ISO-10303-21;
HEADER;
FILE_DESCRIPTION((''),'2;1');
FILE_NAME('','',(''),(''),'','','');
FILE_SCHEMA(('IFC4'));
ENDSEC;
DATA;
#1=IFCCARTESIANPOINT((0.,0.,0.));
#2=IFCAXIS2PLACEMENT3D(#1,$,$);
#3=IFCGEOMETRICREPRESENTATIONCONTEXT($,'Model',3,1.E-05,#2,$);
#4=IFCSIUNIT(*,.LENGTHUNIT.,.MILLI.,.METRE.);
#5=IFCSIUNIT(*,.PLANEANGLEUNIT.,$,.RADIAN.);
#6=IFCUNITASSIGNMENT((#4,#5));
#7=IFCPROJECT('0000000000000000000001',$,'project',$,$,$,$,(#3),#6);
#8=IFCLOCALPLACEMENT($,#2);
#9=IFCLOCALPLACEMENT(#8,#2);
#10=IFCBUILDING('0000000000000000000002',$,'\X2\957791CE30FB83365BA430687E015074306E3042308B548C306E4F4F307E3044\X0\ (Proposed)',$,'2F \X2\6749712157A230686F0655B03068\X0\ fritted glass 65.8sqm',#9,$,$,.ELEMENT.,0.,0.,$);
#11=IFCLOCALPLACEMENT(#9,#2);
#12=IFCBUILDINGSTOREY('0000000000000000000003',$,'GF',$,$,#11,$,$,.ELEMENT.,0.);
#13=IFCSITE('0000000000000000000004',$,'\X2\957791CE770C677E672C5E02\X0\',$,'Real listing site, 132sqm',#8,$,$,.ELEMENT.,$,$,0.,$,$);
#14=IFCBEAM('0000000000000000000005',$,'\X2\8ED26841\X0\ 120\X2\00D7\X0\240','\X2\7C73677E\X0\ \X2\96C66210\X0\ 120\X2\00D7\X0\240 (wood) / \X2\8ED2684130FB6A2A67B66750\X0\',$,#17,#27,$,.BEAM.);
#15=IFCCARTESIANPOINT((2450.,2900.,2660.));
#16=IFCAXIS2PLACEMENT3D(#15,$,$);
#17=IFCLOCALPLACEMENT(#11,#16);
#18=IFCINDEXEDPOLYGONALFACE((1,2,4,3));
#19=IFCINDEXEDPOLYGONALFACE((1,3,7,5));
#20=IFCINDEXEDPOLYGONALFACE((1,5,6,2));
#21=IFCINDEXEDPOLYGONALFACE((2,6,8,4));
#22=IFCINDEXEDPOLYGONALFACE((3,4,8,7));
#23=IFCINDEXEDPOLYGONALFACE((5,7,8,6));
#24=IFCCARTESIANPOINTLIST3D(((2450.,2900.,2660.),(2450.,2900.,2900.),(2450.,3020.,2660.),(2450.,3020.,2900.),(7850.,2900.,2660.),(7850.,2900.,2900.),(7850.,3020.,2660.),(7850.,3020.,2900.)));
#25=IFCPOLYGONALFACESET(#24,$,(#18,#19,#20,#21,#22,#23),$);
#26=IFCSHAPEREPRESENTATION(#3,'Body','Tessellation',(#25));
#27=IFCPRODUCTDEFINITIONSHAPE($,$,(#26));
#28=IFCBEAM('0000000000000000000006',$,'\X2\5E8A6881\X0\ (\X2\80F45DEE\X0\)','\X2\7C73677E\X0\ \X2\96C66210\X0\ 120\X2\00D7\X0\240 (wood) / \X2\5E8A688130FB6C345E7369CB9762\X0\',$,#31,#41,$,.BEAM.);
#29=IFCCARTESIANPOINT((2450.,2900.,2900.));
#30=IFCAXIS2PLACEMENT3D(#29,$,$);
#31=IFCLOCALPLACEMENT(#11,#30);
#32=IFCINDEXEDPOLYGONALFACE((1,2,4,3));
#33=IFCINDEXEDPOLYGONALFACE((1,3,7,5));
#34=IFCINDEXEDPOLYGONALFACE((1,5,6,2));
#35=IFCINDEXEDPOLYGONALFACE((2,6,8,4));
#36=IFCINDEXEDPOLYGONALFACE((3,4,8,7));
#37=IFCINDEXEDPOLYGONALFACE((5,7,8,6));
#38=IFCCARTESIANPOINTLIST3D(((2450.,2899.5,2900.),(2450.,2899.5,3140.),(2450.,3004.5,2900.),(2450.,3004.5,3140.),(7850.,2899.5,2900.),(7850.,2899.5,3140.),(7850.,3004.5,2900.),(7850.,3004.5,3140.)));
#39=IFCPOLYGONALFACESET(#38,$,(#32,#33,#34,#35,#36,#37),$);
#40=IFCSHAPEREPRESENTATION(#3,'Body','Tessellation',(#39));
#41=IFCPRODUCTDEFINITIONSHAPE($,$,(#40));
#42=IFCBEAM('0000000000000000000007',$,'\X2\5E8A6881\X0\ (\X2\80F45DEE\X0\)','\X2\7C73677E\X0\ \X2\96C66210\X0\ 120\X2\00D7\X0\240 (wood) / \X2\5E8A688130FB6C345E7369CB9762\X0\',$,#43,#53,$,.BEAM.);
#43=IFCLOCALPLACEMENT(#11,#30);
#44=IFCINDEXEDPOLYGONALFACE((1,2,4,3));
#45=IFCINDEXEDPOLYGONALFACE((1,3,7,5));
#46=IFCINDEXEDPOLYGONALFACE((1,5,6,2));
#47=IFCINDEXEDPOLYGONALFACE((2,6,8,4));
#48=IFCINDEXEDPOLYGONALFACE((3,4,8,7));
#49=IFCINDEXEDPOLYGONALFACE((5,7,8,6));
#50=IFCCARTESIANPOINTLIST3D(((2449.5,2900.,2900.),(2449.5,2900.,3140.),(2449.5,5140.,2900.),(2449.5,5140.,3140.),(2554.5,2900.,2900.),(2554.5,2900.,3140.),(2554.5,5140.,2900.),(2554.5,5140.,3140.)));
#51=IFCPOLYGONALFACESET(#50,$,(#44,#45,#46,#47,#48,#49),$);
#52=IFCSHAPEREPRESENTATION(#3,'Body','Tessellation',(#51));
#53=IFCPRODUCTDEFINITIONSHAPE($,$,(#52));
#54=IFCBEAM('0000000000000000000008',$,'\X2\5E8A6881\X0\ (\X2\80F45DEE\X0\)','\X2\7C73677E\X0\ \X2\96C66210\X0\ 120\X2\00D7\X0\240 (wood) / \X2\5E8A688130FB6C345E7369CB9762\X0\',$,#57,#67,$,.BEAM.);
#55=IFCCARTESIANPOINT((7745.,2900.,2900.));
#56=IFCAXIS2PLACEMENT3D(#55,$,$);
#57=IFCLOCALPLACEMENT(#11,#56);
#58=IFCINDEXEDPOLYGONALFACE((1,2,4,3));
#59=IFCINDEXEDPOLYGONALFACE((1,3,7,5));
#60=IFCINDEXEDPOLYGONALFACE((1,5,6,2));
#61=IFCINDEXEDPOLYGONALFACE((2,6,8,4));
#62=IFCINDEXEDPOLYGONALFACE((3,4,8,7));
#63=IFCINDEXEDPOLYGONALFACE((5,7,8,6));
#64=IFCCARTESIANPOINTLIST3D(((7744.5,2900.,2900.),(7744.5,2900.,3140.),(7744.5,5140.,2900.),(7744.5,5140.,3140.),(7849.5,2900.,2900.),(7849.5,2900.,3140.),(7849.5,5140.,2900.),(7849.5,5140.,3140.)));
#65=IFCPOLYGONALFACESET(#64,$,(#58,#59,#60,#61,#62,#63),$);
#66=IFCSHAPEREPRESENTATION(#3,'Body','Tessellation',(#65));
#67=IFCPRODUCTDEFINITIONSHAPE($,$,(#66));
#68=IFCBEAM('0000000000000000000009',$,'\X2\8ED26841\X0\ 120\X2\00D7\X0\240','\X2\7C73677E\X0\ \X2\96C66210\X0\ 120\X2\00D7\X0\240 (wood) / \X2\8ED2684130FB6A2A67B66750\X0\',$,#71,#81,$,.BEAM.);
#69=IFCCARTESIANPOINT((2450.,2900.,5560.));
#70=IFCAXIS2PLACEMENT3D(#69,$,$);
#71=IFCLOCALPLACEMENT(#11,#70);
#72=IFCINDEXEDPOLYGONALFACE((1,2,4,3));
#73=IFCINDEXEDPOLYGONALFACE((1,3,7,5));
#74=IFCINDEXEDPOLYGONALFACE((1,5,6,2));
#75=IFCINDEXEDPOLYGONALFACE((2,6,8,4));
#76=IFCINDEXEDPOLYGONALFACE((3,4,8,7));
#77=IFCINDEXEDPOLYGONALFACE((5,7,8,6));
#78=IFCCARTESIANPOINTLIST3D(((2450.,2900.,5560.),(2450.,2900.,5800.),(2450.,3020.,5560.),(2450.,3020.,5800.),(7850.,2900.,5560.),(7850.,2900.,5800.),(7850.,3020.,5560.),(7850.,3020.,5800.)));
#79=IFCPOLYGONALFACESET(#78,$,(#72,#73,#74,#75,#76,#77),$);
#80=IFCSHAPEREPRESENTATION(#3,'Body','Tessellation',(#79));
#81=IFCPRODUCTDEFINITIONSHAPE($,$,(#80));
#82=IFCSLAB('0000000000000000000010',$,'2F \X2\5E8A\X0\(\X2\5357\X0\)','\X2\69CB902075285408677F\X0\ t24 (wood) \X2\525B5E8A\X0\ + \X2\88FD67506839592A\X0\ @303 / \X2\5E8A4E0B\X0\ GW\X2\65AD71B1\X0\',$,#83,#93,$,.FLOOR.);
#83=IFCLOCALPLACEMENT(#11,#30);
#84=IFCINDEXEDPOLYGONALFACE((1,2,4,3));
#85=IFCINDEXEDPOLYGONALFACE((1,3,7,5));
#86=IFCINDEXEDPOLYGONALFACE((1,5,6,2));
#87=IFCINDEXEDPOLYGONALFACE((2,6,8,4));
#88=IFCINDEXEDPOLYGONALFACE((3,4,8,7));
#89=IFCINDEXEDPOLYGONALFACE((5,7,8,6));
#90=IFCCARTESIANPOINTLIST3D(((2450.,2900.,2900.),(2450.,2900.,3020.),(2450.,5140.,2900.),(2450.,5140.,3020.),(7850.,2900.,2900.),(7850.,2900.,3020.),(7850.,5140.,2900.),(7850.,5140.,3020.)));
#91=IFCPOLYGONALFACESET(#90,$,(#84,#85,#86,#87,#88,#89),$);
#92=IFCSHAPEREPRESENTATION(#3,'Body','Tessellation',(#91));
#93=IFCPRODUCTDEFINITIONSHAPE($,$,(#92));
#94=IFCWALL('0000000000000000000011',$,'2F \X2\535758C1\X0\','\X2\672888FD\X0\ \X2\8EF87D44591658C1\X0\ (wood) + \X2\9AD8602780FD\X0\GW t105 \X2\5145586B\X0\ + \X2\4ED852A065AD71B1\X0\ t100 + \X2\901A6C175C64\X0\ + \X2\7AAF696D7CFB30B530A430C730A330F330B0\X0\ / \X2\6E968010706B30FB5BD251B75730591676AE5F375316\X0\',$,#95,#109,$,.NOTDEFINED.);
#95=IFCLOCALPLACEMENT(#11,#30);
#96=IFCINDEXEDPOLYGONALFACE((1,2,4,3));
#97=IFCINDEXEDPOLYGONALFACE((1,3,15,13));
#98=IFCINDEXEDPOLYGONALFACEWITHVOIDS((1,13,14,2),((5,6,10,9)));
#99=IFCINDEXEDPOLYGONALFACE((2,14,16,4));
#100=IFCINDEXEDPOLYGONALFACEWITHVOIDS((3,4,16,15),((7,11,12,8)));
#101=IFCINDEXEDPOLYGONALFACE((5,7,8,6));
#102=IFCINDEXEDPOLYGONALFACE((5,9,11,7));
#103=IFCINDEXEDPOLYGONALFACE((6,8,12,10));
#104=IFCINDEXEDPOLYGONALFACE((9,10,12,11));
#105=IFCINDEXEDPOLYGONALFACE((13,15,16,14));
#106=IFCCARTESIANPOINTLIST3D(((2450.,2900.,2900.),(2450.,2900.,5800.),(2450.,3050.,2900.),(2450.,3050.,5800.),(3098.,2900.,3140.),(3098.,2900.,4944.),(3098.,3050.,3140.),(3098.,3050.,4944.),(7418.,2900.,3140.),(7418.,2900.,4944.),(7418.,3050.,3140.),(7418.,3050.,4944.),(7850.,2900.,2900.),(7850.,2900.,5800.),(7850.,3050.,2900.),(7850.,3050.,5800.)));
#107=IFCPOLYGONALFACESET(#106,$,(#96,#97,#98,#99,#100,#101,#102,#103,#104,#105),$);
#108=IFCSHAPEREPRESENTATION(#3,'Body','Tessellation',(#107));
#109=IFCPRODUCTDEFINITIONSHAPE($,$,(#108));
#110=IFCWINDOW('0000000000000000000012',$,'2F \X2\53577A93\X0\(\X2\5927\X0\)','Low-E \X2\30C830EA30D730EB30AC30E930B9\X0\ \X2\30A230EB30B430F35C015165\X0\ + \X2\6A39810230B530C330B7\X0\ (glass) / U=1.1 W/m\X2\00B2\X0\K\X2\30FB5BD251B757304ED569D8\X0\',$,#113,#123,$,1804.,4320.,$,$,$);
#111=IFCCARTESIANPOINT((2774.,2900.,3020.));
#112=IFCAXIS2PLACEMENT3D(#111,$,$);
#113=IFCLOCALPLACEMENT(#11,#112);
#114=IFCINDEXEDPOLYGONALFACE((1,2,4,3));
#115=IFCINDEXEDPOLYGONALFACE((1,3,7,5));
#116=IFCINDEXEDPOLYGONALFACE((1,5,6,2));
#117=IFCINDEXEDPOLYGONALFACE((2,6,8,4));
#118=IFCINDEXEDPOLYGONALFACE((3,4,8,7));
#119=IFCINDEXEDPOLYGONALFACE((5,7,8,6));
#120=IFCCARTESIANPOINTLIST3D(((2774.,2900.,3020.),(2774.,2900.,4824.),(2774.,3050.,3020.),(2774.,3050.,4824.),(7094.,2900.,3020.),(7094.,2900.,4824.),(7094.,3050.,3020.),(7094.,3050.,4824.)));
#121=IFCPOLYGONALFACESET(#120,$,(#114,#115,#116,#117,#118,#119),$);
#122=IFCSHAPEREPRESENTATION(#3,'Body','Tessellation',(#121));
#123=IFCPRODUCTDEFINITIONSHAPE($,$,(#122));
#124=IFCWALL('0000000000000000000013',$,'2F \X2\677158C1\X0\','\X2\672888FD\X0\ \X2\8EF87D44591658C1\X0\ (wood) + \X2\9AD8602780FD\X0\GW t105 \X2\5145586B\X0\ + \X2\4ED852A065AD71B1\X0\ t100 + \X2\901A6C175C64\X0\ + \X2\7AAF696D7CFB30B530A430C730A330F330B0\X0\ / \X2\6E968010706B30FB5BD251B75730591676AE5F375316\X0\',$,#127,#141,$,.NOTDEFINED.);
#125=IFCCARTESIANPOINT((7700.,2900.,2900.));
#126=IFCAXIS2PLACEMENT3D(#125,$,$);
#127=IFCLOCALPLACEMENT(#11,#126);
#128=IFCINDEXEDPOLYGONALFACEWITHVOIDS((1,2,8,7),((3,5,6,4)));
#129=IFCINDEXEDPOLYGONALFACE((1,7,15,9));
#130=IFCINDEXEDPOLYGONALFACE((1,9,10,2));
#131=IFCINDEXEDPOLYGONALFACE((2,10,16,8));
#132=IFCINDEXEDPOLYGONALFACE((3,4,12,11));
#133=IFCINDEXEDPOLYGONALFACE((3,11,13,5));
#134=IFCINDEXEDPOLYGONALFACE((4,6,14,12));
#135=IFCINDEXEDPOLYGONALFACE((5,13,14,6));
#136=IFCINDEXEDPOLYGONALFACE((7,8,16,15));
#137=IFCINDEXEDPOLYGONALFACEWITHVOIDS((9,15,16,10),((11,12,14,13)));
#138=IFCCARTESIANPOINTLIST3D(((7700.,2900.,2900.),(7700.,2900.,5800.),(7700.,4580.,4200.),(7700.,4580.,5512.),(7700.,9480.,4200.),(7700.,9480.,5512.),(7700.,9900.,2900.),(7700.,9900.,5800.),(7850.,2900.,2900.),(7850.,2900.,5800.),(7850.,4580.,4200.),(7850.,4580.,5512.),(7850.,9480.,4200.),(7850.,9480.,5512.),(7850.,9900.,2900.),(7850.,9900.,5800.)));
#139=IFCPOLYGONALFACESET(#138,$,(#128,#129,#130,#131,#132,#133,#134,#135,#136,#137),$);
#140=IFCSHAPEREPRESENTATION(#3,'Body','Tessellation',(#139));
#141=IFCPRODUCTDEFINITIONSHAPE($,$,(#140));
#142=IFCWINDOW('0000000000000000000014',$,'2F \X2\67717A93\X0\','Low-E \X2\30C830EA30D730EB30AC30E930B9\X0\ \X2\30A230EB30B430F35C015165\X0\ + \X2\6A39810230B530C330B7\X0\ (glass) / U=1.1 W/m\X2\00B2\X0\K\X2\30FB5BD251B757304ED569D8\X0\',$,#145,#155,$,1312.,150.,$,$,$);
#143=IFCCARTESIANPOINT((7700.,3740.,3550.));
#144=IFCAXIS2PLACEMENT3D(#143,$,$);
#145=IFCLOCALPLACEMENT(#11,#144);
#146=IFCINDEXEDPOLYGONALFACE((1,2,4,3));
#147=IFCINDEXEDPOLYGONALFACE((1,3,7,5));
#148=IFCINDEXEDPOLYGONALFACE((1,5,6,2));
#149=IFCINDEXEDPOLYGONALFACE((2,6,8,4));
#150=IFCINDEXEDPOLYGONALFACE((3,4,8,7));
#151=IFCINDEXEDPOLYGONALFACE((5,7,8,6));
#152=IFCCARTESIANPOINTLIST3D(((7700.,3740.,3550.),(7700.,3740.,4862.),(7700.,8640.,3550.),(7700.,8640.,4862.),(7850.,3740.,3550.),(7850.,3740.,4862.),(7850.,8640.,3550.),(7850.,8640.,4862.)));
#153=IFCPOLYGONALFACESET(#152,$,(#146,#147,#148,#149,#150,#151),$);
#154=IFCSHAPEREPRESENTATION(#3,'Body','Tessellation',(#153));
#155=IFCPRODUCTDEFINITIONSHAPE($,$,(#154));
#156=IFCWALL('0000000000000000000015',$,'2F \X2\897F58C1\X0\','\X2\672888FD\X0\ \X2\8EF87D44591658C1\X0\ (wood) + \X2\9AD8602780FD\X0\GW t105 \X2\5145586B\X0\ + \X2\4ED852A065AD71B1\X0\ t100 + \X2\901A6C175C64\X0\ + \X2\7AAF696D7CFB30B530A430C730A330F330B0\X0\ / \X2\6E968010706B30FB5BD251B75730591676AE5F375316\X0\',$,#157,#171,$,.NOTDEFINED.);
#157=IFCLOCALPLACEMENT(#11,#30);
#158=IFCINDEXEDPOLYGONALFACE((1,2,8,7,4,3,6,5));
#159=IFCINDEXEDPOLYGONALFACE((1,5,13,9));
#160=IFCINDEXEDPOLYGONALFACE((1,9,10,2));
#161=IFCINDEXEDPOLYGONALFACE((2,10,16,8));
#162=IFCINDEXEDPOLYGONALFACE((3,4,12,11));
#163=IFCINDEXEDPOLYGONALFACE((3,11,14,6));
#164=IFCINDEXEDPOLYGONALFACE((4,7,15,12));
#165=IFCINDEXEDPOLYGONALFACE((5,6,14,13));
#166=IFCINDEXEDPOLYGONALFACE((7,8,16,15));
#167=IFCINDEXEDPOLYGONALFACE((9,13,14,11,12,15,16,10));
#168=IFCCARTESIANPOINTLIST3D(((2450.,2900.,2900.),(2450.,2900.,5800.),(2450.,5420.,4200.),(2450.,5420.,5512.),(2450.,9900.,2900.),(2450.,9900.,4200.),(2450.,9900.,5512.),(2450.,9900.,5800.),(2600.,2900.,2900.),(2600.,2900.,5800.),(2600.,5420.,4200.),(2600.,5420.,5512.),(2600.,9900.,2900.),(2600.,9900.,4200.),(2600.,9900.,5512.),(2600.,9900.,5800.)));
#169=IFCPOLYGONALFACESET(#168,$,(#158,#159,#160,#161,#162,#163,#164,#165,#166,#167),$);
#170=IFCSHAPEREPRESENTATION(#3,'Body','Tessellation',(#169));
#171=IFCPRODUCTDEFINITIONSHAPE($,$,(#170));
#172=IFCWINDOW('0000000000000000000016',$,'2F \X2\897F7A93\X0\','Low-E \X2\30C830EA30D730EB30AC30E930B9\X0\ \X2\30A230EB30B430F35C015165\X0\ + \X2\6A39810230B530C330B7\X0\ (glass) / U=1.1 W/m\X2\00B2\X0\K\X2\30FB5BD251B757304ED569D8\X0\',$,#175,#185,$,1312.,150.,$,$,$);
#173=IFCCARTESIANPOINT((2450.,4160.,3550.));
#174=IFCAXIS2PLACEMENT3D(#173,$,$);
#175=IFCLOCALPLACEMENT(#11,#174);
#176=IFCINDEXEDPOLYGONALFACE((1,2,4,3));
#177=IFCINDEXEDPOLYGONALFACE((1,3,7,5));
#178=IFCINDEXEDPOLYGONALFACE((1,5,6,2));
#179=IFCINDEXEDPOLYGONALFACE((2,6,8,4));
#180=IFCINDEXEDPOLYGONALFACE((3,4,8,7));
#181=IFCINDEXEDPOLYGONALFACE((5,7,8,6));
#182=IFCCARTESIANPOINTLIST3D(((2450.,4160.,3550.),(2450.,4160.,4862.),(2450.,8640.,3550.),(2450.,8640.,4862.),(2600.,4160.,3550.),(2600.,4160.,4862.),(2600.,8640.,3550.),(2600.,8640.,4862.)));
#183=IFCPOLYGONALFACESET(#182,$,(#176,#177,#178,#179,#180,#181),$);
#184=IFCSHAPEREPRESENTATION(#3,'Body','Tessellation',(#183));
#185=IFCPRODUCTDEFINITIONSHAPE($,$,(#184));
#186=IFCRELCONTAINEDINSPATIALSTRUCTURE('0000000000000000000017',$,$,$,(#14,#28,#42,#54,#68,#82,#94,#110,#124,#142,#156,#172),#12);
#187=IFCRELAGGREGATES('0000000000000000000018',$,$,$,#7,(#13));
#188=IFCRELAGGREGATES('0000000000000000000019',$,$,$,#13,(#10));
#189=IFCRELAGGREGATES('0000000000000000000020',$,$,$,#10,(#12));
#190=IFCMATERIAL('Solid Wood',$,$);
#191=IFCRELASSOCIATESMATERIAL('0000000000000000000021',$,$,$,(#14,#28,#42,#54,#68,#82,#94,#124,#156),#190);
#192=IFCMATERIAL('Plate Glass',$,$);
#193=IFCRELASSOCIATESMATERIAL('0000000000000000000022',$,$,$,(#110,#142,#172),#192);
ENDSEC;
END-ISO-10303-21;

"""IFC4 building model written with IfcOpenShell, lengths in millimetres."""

from ifc_helpers import new_model, si_unit, frame, frame_2d, origin, place, context, project, spatial, rectangle, extrude, material, element, fill, save


model = new_model("IFC4")

# Units and contexts
model_context = context("Model", 3, precision=1e-05, world=origin())
ifc_project = project(units=[si_unit("LENGTHUNIT", "METRE", prefix="MILLI"), si_unit("PLANEANGLEUNIT", "RADIAN")], contexts=[model_context])

# Site, building, storey
site_placement = place(None, origin())
site = spatial("IfcSite", under=ifc_project, at=site_placement, Name="長野県松本市", ObjectType="Real listing site, 132sqm", CompositionType="ELEMENT", RefElevation=0.0)
building_placement = place(site_placement, origin())
building = spatial("IfcBuilding", under=site, at=building_placement, Name="長野・茶室と縁側のある和の住まい (Proposed)", ObjectType="2F 杉無垢と漆喰と fritted glass 65.8sqm", CompositionType="ELEMENT", ElevationOfRefHeight=0.0, ElevationOfTerrain=0.0)
storey_placement = place(building_placement, origin())
storey = spatial("IfcBuildingStorey", under=building, at=storey_placement, Name="GF", CompositionType="ELEMENT", Elevation=0.0)

# Shared definitions
ifc_material_1 = material(Name="Solid Wood")

# Beams
beam_1_placement = place(storey_placement, frame((2450.0, 2900.0, 2660.0)))
element("IfcBeam", 1, at=beam_1_placement, inside=storey, material=ifc_material_1, Name="軒桁 120×240", Description="米松 集成 120×240 (wood) / 軒桁・横架材", PredefinedType="BEAM", context=model_context, shape_type="SweptSolid", body=[
    extrude(rectangle(XDim=5400.0, YDim=120.0, at=frame_2d((2700.0, 60.0))), frame((2450.0, 2900.0, 2660.0)), (0.0, 0.0, 1.0), 240.0),
])
beam_2_placement = place(storey_placement, frame((2450.0, 2900.0, 2900.0)))
element("IfcBeam", 2, at=beam_2_placement, inside=storey, material=ifc_material_1, Name="床梁 (胴差)", Description="米松 集成 120×240 (wood) / 床梁・水平構面", PredefinedType="BEAM", context=model_context, shape_type="SweptSolid", body=[
    extrude(rectangle(XDim=5400.0, YDim=105.0, at=frame_2d((2700.0, 52.0))), frame((2450.0, 2900.0, 2900.0)), (0.0, 0.0, 1.0), 240.0),
])
beam_3_placement = place(storey_placement, frame((2450.0, 2900.0, 2900.0)))
element("IfcBeam", 3, at=beam_3_placement, inside=storey, material=ifc_material_1, Name="床梁 (胴差)", Description="米松 集成 120×240 (wood) / 床梁・水平構面", PredefinedType="BEAM", context=model_context, shape_type="SweptSolid", body=[
    extrude(rectangle(XDim=105.0, YDim=2240.0, at=frame_2d((52.0, 1120.0))), frame((2450.0, 2900.0, 2900.0)), (0.0, 0.0, 1.0), 240.0),
])
beam_4_placement = place(storey_placement, frame((7745.0, 2900.0, 2900.0)))
element("IfcBeam", 4, at=beam_4_placement, inside=storey, material=ifc_material_1, Name="床梁 (胴差)", Description="米松 集成 120×240 (wood) / 床梁・水平構面", PredefinedType="BEAM", context=model_context, shape_type="SweptSolid", body=[
    extrude(rectangle(XDim=105.0, YDim=2240.0, at=frame_2d((52.0, 1120.0))), frame((7745.0, 2900.0, 2900.0)), (0.0, 0.0, 1.0), 240.0),
])
beam_5_placement = place(storey_placement, frame((2450.0, 2900.0, 5560.0)))
element("IfcBeam", 5, at=beam_5_placement, inside=storey, material=ifc_material_1, Name="軒桁 120×240", Description="米松 集成 120×240 (wood) / 軒桁・横架材", PredefinedType="BEAM", context=model_context, shape_type="SweptSolid", body=[
    extrude(rectangle(XDim=5400.0, YDim=120.0, at=frame_2d((2700.0, 60.0))), frame((2450.0, 2900.0, 5560.0)), (0.0, 0.0, 1.0), 240.0),
])

# Slab
slab_placement = place(storey_placement, frame((2450.0, 2900.0, 2900.0)))
element("IfcSlab", 6, at=slab_placement, inside=storey, material=ifc_material_1, Name="2F 床(南)", Description="構造用合板 t24 (wood) 剛床 + 製材根太 @303 / 床下 GW断熱", PredefinedType="FLOOR", context=model_context, shape_type="SweptSolid", body=[
    extrude(rectangle(XDim=5400.0, YDim=2240.0, at=frame_2d((2700.0, 1120.0))), frame((2450.0, 2900.0, 2900.0)), (0.0, 0.0, 1.0), 120.0),
])

# Walls, openings, windows
wall_1_placement = place(storey_placement, frame((2450.0, 2900.0, 2900.0)))
wall_1 = element("IfcWall", 7, at=wall_1_placement, inside=storey, material=ifc_material_1, Name="2F 南壁", Description="木製 軸組外壁 (wood) + 高性能GW t105 充填 + 付加断熱 t100 + 通気層 + 窯業系サイディング / 準耐火・寒冷地外皮強化", PredefinedType="NOTDEFINED", context=model_context, shape_type="SweptSolid", body=[
    extrude(rectangle(XDim=5400.0, YDim=150.0, at=frame_2d((2700.0, 75.0))), frame((2450.0, 2900.0, 2900.0)), (0.0, 0.0, 1.0), 2900.0),
])
opening_1_placement = place(storey_placement, frame((2774.0, 2900.0, 3020.0)))
opening_1 = element("IfcOpeningElement", 8, at=opening_1_placement, cuts=wall_1, PredefinedType="NOTDEFINED", context=model_context, shape_type="SweptSolid", body=[
    extrude(rectangle(XDim=4320.0, YDim=150.0, at=frame_2d((2160.0, 75.0))), frame((2774.0, 2900.0, 3020.0)), (0.0, 0.0, 1.0), 1804.0),
])
ifc_material_2 = material(Name="Plate Glass")
window_1_placement = place(storey_placement, frame((2774.0, 2900.0, 3020.0)))
window_1 = element("IfcWindow", 9, at=window_1_placement, inside=storey, material=ifc_material_2, Name="2F 南窓(大)", Description="Low-E トリプルガラス アルゴン封入 + 樹脂サッシ (glass) / U=1.1 W/m²K・寒冷地仕様", OverallHeight=1804.0, OverallWidth=4320.0, context=model_context, shape_type="SweptSolid", body=[
    extrude(rectangle(XDim=4320.0, YDim=150.0, at=frame_2d((2160.0, 75.0))), frame((2774.0, 2900.0, 3020.0)), (0.0, 0.0, 1.0), 1804.0),
])
fill(opening_1, window_1)
wall_2_placement = place(storey_placement, frame((7700.0, 2900.0, 2900.0)))
wall_2 = element("IfcWall", 10, at=wall_2_placement, inside=storey, material=ifc_material_1, Name="2F 東壁", Description="木製 軸組外壁 (wood) + 高性能GW t105 充填 + 付加断熱 t100 + 通気層 + 窯業系サイディング / 準耐火・寒冷地外皮強化", PredefinedType="NOTDEFINED", context=model_context, shape_type="SweptSolid", body=[
    extrude(rectangle(XDim=150.0, YDim=7000.0, at=frame_2d((75.0, 3500.0))), frame((7700.0, 2900.0, 2900.0)), (0.0, 0.0, 1.0), 2900.0),
])
opening_2_placement = place(storey_placement, frame((7700.0, 3740.0, 3550.0)))
opening_2 = element("IfcOpeningElement", 11, at=opening_2_placement, cuts=wall_2, PredefinedType="NOTDEFINED", context=model_context, shape_type="SweptSolid", body=[
    extrude(rectangle(XDim=150.0, YDim=4900.0, at=frame_2d((75.0, 2450.0))), frame((7700.0, 3740.0, 3550.0)), (0.0, 0.0, 1.0), 1312.0),
])
window_2_placement = place(storey_placement, frame((7700.0, 3740.0, 3550.0)))
window_2 = element("IfcWindow", 12, at=window_2_placement, inside=storey, material=ifc_material_2, Name="2F 東窓", Description="Low-E トリプルガラス アルゴン封入 + 樹脂サッシ (glass) / U=1.1 W/m²K・寒冷地仕様", OverallHeight=1312.0, OverallWidth=150.0, context=model_context, shape_type="SweptSolid", body=[
    extrude(rectangle(XDim=150.0, YDim=4900.0, at=frame_2d((75.0, 2450.0))), frame((7700.0, 3740.0, 3550.0)), (0.0, 0.0, 1.0), 1312.0),
])
fill(opening_2, window_2)
wall_3_placement = place(storey_placement, frame((2450.0, 2900.0, 2900.0)))
wall_3 = element("IfcWall", 13, at=wall_3_placement, inside=storey, material=ifc_material_1, Name="2F 西壁", Description="木製 軸組外壁 (wood) + 高性能GW t105 充填 + 付加断熱 t100 + 通気層 + 窯業系サイディング / 準耐火・寒冷地外皮強化", PredefinedType="NOTDEFINED", context=model_context, shape_type="SweptSolid", body=[
    extrude(rectangle(XDim=150.0, YDim=7000.0, at=frame_2d((75.0, 3500.0))), frame((2450.0, 2900.0, 2900.0)), (0.0, 0.0, 1.0), 2900.0),
])
opening_3_placement = place(storey_placement, frame((2450.0, 4160.0, 3550.0)))
opening_3 = element("IfcOpeningElement", 14, at=opening_3_placement, cuts=wall_3, PredefinedType="NOTDEFINED", context=model_context, shape_type="SweptSolid", body=[
    extrude(rectangle(XDim=150.0, YDim=4480.0, at=frame_2d((75.0, 2240.0))), frame((2450.0, 4160.0, 3550.0)), (0.0, 0.0, 1.0), 1312.0),
])
window_3_placement = place(storey_placement, frame((2450.0, 4160.0, 3550.0)))
window_3 = element("IfcWindow", 15, at=window_3_placement, inside=storey, material=ifc_material_2, Name="2F 西窓", Description="Low-E トリプルガラス アルゴン封入 + 樹脂サッシ (glass) / U=1.1 W/m²K・寒冷地仕様", OverallHeight=1312.0, OverallWidth=150.0, context=model_context, shape_type="SweptSolid", body=[
    extrude(rectangle(XDim=150.0, YDim=4480.0, at=frame_2d((75.0, 2240.0))), frame((2450.0, 4160.0, 3550.0)), (0.0, 0.0, 1.0), 1312.0),
])
fill(opening_3, window_3)

save(model, "model.ifc")
